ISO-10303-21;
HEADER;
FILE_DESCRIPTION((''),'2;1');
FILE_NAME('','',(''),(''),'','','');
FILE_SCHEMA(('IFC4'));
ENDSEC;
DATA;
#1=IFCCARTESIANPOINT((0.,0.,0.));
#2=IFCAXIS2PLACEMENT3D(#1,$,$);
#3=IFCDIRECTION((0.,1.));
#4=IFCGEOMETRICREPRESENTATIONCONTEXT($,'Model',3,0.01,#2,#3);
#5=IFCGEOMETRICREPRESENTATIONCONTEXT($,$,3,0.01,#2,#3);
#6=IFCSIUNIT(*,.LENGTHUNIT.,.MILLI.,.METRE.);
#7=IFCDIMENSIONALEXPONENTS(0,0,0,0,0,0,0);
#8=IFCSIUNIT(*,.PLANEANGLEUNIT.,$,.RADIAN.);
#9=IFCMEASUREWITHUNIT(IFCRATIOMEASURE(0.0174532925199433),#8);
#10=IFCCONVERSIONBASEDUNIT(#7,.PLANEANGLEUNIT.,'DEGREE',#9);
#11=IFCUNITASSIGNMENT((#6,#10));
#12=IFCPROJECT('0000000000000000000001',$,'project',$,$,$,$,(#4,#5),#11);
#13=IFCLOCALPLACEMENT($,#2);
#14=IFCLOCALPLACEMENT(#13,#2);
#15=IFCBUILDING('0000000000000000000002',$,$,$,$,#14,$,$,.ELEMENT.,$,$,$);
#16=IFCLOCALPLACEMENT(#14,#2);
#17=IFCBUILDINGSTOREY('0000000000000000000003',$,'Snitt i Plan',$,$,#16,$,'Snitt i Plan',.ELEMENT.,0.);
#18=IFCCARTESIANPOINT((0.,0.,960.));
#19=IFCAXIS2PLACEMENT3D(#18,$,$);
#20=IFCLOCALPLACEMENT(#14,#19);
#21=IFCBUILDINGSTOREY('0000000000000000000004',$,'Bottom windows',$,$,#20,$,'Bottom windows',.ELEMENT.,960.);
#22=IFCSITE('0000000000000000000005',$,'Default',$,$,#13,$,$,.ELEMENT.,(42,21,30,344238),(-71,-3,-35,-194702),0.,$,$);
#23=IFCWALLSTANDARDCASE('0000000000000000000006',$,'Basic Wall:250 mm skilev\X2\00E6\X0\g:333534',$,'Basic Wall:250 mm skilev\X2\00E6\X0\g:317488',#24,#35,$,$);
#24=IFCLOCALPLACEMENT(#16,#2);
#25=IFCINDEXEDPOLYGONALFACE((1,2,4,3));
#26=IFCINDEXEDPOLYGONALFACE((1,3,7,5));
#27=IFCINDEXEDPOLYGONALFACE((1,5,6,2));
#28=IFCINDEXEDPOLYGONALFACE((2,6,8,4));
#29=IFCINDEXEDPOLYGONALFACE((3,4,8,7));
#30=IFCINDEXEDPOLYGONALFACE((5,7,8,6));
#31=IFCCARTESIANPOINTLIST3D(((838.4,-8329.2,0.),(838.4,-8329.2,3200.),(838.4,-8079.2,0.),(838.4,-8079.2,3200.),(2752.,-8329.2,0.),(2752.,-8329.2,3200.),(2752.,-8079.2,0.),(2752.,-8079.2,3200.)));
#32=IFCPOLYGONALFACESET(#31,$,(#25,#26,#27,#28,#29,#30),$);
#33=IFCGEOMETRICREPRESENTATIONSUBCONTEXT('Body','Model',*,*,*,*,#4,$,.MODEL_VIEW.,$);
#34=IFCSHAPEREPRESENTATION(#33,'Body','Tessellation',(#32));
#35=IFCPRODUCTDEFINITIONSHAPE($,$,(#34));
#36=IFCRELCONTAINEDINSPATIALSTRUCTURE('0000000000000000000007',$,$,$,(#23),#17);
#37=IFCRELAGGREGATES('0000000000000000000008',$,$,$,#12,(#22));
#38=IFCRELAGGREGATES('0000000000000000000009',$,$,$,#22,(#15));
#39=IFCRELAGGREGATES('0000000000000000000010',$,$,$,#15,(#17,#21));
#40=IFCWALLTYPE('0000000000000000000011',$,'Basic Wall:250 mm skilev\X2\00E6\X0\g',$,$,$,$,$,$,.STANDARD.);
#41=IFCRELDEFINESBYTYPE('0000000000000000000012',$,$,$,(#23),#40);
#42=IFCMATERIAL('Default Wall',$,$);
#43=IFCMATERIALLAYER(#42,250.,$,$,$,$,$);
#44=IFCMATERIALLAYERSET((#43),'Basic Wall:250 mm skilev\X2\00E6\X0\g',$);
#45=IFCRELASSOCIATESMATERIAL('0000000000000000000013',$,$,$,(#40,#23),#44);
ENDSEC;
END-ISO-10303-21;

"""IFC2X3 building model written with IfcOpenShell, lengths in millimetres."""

from ifc_helpers import new_model, entity, si_unit, converted_unit, direction, frame, frame_2d, origin, place, context, subcontext, project, spatial, rectangle, extrude, material, layer, layer_set, layer_usage, type_object, element, save


model = new_model("IFC2X3")

# Units and contexts
model_context = context("Model", 3, precision=0.01, world=origin(), true_north=direction((0.0, 1.0)))
context_of_model = context(None, 3, precision=0.01, world=origin(), true_north=direction((0.0, 1.0)))
body_context = subcontext(model_context, "Body", "Model", "MODEL_VIEW")
ifc_project = project(units=[si_unit("LENGTHUNIT", "METRE", prefix="MILLI"), converted_unit("PLANEANGLEUNIT", "DEGREE", entity("IfcRatioMeasure", 0.0174532925199433), si_unit("PLANEANGLEUNIT", "RADIAN"), dimensions=[0, 0, 0, 0, 0, 0, 0])], contexts=[model_context, context_of_model])

# Site, building, storey
site_placement = place(None, origin())
site = spatial("IfcSite", under=ifc_project, at=site_placement, Name="Default", CompositionType="ELEMENT", RefLatitude=(42, 21, 30, 344238), RefLongitude=(-71, -3, -35, -194702), RefElevation=0.0)
building_placement = place(site_placement, origin())
building = spatial("IfcBuilding", under=site, at=building_placement, CompositionType="ELEMENT")
storey_1_placement = place(building_placement, origin())
storey_1 = spatial("IfcBuildingStorey", under=building, at=storey_1_placement, Name="Snitt i Plan", LongName="Snitt i Plan", CompositionType="ELEMENT", Elevation=0.0)

# Shared definitions
storey_2_placement = place(building_placement, frame((0.0, 0.0, 960.0)))
storey_2 = spatial("IfcBuildingStorey", under=building, at=storey_2_placement, Name="Bottom windows", LongName="Bottom windows", CompositionType="ELEMENT", Elevation=960.0)

# Shared definitions
ifc_material_1 = material(Name="Default Wall")
ifc_layer_1 = layer(ifc_material_1, 250.0)
ifc_layer_set_1 = layer_set([ifc_layer_1], Name="Basic Wall:250 mm skilevæg")
wall_type_1 = type_object("IfcWallType", Name="Basic Wall:250 mm skilevæg", PredefinedType="STANDARD", material=ifc_layer_set_1)

# Wall
ifc_layer_usage_1 = layer_usage(ifc_layer_set_1, "AXIS2", "NEGATIVE", 125.0)
wall_1_placement = place(storey_1_placement, frame((838.4, -8204.2, 0.0)))
element("IfcWallStandardCase", 1, at=wall_1_placement, inside=storey_1, type_object=wall_type_1, material=ifc_layer_usage_1, Name="Basic Wall:250 mm skilevæg:333534", ObjectType="Basic Wall:250 mm skilevæg:317488", context=body_context, shape_type="SweptSolid", body=[
    extrude(rectangle(XDim=1913.6, YDim=250.0, at=frame_2d((956.8, 0.0), x_axis=(-1.0, 0.0))), origin(), (0.0, 0.0, 1.0), 3200.0),
])

save(model, "model.ifc")
